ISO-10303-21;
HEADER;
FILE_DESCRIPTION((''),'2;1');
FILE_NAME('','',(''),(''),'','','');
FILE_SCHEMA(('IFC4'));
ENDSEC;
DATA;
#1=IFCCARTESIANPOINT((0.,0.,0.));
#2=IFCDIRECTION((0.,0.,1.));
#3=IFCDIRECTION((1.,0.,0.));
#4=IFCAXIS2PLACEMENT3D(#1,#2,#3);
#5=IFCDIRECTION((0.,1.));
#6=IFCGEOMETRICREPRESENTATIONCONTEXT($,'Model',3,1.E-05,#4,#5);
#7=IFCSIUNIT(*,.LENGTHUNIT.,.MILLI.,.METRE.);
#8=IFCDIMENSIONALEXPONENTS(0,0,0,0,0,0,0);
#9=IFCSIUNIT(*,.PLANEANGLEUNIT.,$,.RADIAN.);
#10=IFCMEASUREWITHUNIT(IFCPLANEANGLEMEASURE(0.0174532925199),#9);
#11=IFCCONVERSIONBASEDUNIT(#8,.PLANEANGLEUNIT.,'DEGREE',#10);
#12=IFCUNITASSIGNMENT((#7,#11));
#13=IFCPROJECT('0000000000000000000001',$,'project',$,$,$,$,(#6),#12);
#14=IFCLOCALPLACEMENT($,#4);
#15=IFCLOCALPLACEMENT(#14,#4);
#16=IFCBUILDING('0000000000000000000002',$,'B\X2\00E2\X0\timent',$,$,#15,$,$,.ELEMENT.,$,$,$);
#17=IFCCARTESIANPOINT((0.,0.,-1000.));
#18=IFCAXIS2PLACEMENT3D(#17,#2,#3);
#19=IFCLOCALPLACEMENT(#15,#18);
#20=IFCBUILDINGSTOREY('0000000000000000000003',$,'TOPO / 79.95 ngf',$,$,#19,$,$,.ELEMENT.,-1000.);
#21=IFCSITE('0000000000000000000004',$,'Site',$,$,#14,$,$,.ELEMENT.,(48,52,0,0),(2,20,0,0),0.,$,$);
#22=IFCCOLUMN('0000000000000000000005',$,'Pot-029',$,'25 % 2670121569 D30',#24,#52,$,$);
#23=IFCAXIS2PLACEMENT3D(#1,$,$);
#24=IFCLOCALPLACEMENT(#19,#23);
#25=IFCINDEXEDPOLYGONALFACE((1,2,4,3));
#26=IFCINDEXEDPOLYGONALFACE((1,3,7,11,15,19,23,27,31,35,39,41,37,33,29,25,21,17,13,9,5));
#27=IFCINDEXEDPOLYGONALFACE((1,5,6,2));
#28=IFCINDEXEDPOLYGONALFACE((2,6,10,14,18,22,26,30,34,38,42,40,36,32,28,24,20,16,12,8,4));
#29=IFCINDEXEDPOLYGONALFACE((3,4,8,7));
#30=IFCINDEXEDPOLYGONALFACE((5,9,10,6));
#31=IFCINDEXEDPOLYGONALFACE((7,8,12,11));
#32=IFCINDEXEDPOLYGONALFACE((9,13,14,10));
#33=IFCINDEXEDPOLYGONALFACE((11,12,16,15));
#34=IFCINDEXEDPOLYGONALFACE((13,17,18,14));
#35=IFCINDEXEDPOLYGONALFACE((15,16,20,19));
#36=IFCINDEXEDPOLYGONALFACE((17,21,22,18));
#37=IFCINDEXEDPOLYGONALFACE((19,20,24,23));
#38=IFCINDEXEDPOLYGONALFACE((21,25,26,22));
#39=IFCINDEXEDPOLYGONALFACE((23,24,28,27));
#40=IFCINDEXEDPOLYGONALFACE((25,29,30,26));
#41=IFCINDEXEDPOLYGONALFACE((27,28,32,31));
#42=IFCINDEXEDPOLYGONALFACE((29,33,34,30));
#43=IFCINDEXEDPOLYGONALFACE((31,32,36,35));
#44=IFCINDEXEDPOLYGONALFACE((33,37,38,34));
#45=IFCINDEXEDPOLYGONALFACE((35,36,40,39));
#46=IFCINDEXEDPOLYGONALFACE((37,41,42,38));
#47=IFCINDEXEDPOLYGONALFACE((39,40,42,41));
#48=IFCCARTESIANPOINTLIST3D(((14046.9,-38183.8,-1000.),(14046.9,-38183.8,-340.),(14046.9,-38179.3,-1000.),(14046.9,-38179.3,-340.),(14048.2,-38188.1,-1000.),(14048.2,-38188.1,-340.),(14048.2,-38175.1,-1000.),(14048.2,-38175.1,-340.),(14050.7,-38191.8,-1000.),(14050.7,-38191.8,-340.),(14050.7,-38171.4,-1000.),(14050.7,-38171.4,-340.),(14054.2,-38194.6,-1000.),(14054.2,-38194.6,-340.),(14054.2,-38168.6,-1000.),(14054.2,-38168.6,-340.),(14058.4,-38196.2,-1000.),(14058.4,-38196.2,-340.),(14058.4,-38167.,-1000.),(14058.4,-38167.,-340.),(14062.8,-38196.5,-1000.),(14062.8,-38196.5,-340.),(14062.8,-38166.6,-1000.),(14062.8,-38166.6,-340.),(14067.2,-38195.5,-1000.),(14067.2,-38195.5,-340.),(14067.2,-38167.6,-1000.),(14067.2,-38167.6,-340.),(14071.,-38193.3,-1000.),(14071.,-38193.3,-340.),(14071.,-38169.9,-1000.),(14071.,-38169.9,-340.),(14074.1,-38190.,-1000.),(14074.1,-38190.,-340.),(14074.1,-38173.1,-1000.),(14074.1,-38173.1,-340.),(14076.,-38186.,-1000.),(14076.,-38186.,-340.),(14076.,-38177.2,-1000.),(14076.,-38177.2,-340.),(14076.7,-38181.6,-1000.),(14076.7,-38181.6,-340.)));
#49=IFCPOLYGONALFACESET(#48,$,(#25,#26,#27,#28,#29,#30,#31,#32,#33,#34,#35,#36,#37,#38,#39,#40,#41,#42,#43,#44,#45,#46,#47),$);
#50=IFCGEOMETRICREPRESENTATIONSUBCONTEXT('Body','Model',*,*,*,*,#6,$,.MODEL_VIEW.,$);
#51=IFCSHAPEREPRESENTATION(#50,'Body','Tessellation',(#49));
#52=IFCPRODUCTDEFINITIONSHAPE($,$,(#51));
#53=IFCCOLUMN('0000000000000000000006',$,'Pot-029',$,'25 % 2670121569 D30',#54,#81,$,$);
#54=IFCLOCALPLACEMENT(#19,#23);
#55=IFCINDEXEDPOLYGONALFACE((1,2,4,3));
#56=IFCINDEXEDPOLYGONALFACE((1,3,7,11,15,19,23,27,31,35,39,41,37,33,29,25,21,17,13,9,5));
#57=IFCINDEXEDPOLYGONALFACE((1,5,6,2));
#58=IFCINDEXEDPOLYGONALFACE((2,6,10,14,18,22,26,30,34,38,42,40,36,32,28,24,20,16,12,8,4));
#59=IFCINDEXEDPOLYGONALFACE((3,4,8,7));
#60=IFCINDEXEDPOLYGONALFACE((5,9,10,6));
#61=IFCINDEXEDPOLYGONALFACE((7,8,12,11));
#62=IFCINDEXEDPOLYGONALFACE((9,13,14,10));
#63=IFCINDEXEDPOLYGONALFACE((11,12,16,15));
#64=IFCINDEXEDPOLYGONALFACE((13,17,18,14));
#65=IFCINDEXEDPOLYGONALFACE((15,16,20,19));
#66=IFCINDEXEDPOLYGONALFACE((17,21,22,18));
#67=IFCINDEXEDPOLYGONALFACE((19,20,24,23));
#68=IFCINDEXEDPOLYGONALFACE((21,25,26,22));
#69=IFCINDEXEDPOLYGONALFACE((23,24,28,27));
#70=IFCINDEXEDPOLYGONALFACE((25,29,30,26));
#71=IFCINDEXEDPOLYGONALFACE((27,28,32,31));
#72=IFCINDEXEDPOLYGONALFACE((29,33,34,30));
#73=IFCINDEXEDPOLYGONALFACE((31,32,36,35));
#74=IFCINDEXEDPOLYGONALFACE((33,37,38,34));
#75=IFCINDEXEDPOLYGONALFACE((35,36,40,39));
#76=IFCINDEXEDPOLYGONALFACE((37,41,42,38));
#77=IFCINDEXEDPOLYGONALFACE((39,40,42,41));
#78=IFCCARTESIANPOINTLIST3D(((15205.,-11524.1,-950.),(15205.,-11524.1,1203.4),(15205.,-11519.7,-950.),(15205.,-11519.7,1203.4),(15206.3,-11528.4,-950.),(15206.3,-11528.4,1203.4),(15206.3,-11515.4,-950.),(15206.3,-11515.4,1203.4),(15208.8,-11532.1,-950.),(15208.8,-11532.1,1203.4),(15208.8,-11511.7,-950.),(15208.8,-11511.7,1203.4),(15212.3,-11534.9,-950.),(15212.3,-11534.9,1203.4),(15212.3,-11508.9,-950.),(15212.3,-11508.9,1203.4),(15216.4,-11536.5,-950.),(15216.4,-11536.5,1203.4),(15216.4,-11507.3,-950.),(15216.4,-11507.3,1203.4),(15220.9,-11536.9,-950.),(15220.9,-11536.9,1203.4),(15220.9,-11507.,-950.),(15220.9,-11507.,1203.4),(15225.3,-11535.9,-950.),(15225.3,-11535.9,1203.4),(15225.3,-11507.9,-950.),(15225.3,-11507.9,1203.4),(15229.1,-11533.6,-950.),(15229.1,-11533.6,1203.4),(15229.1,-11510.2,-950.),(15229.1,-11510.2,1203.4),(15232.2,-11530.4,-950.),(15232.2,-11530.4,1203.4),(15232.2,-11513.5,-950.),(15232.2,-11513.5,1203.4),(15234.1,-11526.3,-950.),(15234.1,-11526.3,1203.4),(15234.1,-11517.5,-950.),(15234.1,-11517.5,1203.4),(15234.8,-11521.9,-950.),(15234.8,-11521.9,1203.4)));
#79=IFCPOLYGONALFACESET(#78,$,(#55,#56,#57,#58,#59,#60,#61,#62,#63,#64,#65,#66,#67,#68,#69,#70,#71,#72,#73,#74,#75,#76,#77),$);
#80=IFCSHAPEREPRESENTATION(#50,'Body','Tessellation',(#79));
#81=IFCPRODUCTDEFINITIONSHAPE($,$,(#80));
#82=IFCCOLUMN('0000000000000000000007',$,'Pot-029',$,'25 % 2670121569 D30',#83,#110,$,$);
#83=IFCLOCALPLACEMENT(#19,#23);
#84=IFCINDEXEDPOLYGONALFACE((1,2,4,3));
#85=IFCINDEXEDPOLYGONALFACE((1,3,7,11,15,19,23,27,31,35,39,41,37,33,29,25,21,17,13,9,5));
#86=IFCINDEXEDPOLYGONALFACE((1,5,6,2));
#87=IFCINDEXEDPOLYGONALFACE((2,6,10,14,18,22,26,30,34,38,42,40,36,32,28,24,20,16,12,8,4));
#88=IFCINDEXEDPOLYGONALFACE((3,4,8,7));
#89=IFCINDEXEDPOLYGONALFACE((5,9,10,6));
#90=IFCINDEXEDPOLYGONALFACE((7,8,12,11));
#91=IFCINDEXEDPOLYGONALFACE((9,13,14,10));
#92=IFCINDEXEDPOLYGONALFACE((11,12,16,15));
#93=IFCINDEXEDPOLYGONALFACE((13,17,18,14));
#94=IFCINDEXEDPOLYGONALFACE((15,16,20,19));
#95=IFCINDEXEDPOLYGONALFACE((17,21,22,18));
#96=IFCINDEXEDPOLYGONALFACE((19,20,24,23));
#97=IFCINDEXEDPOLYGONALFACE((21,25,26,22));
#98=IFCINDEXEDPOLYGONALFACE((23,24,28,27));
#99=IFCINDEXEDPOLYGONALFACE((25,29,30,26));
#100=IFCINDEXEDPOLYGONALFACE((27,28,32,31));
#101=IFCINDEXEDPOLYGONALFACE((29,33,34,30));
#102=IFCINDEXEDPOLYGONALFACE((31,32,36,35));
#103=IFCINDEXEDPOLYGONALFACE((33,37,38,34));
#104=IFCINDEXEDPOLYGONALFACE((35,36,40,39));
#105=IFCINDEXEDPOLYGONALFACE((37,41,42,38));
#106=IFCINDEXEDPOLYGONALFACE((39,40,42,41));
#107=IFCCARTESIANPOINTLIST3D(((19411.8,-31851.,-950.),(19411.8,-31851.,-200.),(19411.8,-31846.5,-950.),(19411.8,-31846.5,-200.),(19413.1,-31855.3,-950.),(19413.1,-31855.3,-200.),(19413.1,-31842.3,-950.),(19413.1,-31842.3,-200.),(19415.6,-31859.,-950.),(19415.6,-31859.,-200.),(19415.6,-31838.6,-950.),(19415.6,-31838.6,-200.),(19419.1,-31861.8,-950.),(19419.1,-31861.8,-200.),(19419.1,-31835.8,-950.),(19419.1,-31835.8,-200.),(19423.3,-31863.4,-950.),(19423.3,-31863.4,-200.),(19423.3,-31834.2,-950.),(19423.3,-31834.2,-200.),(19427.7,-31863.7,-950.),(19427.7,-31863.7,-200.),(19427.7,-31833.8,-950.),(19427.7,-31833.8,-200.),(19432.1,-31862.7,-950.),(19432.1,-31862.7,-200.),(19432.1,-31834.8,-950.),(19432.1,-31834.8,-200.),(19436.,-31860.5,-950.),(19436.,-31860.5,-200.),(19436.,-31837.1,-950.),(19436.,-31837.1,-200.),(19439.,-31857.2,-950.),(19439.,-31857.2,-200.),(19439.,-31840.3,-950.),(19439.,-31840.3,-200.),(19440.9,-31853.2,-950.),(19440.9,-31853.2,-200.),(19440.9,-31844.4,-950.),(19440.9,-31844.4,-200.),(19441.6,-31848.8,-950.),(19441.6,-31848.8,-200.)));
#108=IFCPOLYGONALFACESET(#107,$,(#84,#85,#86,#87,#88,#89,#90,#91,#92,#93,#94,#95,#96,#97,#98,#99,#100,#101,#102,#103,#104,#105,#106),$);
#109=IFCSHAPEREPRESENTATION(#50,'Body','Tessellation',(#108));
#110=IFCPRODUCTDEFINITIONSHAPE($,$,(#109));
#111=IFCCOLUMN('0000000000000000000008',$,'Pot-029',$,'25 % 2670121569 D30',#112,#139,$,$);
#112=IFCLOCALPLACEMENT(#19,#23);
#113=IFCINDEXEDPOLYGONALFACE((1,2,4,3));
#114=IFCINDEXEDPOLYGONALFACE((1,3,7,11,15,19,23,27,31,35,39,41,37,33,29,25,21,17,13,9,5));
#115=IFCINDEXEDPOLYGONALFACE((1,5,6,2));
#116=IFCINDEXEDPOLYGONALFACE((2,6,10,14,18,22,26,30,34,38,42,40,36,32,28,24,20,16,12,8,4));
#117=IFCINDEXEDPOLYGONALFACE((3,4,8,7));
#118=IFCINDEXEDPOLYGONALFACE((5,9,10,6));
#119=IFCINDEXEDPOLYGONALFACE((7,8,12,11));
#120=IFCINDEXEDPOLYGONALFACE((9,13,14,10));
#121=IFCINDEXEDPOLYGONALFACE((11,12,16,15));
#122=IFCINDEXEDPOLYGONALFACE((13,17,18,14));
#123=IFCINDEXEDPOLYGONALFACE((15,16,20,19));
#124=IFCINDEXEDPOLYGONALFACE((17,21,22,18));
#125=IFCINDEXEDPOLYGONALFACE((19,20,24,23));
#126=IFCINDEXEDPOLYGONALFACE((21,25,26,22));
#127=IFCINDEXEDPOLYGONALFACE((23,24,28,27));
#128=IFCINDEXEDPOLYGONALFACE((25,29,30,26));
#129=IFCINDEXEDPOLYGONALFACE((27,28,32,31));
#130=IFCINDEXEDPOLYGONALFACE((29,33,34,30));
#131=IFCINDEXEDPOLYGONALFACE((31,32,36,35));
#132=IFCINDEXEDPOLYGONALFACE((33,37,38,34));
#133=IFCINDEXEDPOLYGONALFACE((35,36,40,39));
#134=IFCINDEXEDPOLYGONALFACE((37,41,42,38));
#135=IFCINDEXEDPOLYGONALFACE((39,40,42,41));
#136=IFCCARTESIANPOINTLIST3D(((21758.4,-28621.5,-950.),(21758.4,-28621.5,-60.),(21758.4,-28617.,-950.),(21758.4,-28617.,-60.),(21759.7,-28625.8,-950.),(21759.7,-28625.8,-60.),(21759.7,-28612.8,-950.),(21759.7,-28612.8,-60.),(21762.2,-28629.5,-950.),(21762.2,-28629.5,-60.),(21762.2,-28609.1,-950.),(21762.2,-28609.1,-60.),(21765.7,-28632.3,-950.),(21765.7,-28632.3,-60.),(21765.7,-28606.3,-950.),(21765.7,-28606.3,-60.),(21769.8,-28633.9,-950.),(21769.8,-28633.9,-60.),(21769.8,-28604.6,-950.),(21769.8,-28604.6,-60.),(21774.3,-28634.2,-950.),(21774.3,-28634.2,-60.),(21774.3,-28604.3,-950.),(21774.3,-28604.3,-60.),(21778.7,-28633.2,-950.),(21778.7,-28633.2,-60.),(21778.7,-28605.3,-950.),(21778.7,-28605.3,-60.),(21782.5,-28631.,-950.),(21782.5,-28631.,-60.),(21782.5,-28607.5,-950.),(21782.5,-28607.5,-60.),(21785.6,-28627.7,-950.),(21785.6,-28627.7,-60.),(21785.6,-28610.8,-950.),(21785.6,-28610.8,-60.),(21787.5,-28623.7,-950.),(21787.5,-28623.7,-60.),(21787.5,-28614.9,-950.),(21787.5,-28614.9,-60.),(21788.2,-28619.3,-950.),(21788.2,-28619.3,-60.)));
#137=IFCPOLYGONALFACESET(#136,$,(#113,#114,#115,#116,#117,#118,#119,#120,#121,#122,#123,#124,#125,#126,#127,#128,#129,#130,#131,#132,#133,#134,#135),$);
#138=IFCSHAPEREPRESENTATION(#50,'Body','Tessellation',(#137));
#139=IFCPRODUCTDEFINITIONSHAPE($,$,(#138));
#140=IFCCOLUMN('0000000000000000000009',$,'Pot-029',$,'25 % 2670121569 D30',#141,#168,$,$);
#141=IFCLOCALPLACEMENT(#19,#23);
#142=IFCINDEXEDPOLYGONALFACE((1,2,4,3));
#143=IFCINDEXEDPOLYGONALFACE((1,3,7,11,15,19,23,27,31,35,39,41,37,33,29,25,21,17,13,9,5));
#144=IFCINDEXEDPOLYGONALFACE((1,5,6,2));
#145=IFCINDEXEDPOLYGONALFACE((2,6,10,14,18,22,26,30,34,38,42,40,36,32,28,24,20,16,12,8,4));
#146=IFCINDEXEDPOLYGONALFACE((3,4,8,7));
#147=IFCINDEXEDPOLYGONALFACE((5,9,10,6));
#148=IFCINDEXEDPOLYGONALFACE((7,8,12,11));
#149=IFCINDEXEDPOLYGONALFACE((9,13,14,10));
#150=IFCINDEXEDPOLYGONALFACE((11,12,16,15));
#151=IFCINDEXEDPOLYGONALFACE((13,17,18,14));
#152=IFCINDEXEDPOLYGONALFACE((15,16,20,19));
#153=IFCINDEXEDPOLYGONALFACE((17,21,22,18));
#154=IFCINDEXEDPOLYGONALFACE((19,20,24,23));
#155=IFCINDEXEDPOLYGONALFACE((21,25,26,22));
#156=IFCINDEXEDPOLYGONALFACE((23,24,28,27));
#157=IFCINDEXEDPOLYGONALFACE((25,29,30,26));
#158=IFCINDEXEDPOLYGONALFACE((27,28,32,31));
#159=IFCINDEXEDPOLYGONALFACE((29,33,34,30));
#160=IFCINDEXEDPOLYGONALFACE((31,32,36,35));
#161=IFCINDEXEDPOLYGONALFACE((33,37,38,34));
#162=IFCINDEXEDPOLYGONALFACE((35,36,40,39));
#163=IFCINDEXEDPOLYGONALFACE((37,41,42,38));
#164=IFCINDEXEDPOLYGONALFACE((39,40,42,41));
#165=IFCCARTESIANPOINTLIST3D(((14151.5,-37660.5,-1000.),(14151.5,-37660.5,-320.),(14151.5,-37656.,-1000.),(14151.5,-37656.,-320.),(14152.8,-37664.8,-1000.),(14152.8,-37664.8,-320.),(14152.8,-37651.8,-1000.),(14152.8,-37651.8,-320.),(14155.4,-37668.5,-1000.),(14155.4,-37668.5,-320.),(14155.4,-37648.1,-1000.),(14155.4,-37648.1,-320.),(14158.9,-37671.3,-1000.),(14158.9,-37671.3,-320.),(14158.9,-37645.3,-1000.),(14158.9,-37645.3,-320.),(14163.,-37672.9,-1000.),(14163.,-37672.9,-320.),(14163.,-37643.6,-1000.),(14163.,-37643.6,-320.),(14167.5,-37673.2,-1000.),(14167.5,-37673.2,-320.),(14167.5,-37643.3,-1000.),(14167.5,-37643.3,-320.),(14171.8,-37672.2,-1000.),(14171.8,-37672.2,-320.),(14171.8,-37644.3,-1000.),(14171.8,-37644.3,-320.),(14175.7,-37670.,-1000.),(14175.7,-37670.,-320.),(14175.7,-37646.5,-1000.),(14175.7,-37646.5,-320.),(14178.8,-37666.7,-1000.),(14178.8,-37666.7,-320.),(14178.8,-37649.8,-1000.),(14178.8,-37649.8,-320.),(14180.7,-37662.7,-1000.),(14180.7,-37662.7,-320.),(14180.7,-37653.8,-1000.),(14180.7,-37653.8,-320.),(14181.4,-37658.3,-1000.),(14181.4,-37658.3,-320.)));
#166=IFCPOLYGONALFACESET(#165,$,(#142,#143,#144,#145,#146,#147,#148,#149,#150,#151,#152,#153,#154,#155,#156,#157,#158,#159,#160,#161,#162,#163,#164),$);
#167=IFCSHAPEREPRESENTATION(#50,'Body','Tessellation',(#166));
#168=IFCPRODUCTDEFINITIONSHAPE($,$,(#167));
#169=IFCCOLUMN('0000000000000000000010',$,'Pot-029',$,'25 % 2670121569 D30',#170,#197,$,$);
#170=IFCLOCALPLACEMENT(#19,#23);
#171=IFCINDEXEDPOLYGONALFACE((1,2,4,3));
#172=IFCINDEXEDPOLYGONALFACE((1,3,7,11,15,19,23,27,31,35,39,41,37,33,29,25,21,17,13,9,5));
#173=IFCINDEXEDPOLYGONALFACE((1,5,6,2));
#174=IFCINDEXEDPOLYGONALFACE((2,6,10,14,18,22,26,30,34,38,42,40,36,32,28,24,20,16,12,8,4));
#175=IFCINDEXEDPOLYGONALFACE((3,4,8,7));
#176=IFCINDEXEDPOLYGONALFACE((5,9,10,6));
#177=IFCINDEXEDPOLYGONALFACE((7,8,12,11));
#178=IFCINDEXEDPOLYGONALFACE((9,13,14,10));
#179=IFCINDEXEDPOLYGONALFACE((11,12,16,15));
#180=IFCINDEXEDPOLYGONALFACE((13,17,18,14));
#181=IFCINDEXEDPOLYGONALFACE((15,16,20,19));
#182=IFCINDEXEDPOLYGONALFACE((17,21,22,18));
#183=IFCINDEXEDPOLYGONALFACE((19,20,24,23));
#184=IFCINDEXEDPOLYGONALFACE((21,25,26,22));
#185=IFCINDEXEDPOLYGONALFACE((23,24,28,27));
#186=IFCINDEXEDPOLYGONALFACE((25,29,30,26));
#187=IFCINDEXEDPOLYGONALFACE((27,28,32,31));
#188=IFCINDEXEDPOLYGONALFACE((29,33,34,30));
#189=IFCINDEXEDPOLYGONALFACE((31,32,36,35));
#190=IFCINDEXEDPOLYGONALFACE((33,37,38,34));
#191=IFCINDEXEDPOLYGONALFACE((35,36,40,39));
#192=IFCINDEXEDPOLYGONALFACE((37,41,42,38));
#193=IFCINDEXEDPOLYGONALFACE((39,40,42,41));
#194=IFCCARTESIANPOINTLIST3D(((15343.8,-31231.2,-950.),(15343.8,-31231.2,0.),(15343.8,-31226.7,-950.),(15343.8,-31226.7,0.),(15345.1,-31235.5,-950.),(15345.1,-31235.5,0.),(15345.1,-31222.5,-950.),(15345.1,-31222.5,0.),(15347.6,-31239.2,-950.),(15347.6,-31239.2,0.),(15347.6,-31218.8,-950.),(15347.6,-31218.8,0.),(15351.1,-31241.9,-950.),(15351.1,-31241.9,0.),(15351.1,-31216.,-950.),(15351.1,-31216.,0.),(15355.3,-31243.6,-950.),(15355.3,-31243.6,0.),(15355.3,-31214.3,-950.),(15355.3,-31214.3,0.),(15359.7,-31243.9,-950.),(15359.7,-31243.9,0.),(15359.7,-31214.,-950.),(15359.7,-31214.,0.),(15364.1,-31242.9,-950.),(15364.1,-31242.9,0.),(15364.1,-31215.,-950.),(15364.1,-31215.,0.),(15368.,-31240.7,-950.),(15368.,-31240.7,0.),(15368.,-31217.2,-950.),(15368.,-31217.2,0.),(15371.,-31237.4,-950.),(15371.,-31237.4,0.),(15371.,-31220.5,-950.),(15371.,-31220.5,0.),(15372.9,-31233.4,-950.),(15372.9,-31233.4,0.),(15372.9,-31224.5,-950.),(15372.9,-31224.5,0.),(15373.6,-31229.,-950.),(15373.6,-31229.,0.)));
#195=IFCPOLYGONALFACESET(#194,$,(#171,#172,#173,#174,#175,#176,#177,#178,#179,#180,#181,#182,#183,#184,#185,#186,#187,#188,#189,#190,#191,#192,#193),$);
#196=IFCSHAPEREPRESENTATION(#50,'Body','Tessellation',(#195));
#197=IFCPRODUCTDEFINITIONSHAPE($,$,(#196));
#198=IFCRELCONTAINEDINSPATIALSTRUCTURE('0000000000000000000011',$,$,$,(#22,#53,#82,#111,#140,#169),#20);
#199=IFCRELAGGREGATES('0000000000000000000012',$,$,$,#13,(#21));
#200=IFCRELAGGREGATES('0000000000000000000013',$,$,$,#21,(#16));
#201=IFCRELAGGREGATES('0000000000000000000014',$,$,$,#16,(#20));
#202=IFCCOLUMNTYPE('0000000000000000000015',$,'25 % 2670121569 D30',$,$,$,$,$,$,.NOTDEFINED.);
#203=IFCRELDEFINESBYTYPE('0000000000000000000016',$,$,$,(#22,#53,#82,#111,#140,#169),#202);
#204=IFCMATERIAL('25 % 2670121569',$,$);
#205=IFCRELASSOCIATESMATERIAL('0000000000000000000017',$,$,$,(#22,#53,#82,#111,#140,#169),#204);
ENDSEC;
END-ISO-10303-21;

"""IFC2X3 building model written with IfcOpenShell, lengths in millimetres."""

from ifc_helpers import new_model, entity, si_unit, converted_unit, direction, frame, origin_with_axes, origin_2d_with_axis, place, context, subcontext, project, spatial, circle, extrude, material, type_object, element, save


model = new_model("IFC2X3")

# Units and contexts
model_context = context("Model", 3, precision=1e-05, world=origin_with_axes(), true_north=direction((0.0, 1.0)))
body_context = subcontext(model_context, "Body", "Model", "MODEL_VIEW")
ifc_project = project(units=[si_unit("LENGTHUNIT", "METRE", prefix="MILLI"), converted_unit("PLANEANGLEUNIT", "DEGREE", entity("IfcPlaneAngleMeasure", 0.0174532925199), si_unit("PLANEANGLEUNIT", "RADIAN"), dimensions=[0, 0, 0, 0, 0, 0, 0])], contexts=[model_context])

# Site, building, storey
site_placement = place(None, origin_with_axes())
site = spatial("IfcSite", under=ifc_project, at=site_placement, Name="Site", CompositionType="ELEMENT", RefLatitude=(48, 52, 0, 0), RefLongitude=(2, 20, 0, 0), RefElevation=0.0)
building_placement = place(site_placement, origin_with_axes())
building = spatial("IfcBuilding", under=site, at=building_placement, Name="Bâtiment", CompositionType="ELEMENT")
storey_placement = place(building_placement, frame((0.0, 0.0, -1000.0), z_axis=(0.0, 0.0, 1.0), x_axis=(1.0, 0.0, 0.0)))
storey = spatial("IfcBuildingStorey", under=building, at=storey_placement, Name="TOPO / 79.95 ngf", CompositionType="ELEMENT", Elevation=-1000.0)

# Columns
ifc_material_1 = material(Name="25 % 2670121569")
column_type = type_object("IfcColumnType", Name="25 % 2670121569 D30", PredefinedType="NOTDEFINED")
column_1_placement = place(storey_placement, frame((14061.7, -38181.6, -1000.0), z_axis=(0.0, 0.0, 1.0), x_axis=(1.0, 0.0, 0.0)))
element("IfcColumn", 1, at=column_1_placement, inside=storey, type_object=column_type, material=ifc_material_1, Name="Pot-029", ObjectType="25 % 2670121569 D30", context=body_context, shape_type="SweptSolid", body=[
    extrude(circle(Radius=15.0, at=origin_2d_with_axis()), origin_with_axes(), (0.0, 0.0, 1.0), 660.0),
])
column_2_placement = place(storey_placement, frame((15219.8, -11521.9, -950.0), z_axis=(0.0, 0.0, 1.0), x_axis=(1.0, 0.0, 0.0)))
element("IfcColumn", 2, at=column_2_placement, inside=storey, type_object=column_type, material=ifc_material_1, Name="Pot-029", ObjectType="25 % 2670121569 D30", context=body_context, shape_type="SweptSolid", body=[
    extrude(circle(Radius=15.0, at=origin_2d_with_axis()), origin_with_axes(), (0.0, 0.0, 1.0), 2153.4),
])
column_3_placement = place(storey_placement, frame((19426.6, -31848.8, -950.0), z_axis=(0.0, 0.0, 1.0), x_axis=(1.0, 0.0, 0.0)))
element("IfcColumn", 3, at=column_3_placement, inside=storey, type_object=column_type, material=ifc_material_1, Name="Pot-029", ObjectType="25 % 2670121569 D30", context=body_context, shape_type="SweptSolid", body=[
    extrude(circle(Radius=15.0, at=origin_2d_with_axis()), origin_with_axes(), (0.0, 0.0, 1.0), 750.0),
])
column_4_placement = place(storey_placement, frame((21773.2, -28619.3, -950.0), z_axis=(0.0, 0.0, 1.0), x_axis=(1.0, 0.0, 0.0)))
element("IfcColumn", 4, at=column_4_placement, inside=storey, type_object=column_type, material=ifc_material_1, Name="Pot-029", ObjectType="25 % 2670121569 D30", context=body_context, shape_type="SweptSolid", body=[
    extrude(circle(Radius=15.0, at=origin_2d_with_axis()), origin_with_axes(), (0.0, 0.0, 1.0), 890.0),
])
column_5_placement = place(storey_placement, frame((14166.4, -37658.3, -1000.0), z_axis=(0.0, 0.0, 1.0), x_axis=(1.0, 0.0, 0.0)))
element("IfcColumn", 5, at=column_5_placement, inside=storey, type_object=column_type, material=ifc_material_1, Name="Pot-029", ObjectType="25 % 2670121569 D30", context=body_context, shape_type="SweptSolid", body=[
    extrude(circle(Radius=15.0, at=origin_2d_with_axis()), origin_with_axes(), (0.0, 0.0, 1.0), 680.0),
])
column_6_placement = place(storey_placement, frame((15358.6, -31229.0, -950.0), z_axis=(0.0, 0.0, 1.0), x_axis=(1.0, 0.0, 0.0)))
element("IfcColumn", 6, at=column_6_placement, inside=storey, type_object=column_type, material=ifc_material_1, Name="Pot-029", ObjectType="25 % 2670121569 D30", context=body_context, shape_type="SweptSolid", body=[
    extrude(circle(Radius=15.0, at=origin_2d_with_axis()), origin_with_axes(), (0.0, 0.0, 1.0), 950.0),
])

save(model, "model.ifc")
